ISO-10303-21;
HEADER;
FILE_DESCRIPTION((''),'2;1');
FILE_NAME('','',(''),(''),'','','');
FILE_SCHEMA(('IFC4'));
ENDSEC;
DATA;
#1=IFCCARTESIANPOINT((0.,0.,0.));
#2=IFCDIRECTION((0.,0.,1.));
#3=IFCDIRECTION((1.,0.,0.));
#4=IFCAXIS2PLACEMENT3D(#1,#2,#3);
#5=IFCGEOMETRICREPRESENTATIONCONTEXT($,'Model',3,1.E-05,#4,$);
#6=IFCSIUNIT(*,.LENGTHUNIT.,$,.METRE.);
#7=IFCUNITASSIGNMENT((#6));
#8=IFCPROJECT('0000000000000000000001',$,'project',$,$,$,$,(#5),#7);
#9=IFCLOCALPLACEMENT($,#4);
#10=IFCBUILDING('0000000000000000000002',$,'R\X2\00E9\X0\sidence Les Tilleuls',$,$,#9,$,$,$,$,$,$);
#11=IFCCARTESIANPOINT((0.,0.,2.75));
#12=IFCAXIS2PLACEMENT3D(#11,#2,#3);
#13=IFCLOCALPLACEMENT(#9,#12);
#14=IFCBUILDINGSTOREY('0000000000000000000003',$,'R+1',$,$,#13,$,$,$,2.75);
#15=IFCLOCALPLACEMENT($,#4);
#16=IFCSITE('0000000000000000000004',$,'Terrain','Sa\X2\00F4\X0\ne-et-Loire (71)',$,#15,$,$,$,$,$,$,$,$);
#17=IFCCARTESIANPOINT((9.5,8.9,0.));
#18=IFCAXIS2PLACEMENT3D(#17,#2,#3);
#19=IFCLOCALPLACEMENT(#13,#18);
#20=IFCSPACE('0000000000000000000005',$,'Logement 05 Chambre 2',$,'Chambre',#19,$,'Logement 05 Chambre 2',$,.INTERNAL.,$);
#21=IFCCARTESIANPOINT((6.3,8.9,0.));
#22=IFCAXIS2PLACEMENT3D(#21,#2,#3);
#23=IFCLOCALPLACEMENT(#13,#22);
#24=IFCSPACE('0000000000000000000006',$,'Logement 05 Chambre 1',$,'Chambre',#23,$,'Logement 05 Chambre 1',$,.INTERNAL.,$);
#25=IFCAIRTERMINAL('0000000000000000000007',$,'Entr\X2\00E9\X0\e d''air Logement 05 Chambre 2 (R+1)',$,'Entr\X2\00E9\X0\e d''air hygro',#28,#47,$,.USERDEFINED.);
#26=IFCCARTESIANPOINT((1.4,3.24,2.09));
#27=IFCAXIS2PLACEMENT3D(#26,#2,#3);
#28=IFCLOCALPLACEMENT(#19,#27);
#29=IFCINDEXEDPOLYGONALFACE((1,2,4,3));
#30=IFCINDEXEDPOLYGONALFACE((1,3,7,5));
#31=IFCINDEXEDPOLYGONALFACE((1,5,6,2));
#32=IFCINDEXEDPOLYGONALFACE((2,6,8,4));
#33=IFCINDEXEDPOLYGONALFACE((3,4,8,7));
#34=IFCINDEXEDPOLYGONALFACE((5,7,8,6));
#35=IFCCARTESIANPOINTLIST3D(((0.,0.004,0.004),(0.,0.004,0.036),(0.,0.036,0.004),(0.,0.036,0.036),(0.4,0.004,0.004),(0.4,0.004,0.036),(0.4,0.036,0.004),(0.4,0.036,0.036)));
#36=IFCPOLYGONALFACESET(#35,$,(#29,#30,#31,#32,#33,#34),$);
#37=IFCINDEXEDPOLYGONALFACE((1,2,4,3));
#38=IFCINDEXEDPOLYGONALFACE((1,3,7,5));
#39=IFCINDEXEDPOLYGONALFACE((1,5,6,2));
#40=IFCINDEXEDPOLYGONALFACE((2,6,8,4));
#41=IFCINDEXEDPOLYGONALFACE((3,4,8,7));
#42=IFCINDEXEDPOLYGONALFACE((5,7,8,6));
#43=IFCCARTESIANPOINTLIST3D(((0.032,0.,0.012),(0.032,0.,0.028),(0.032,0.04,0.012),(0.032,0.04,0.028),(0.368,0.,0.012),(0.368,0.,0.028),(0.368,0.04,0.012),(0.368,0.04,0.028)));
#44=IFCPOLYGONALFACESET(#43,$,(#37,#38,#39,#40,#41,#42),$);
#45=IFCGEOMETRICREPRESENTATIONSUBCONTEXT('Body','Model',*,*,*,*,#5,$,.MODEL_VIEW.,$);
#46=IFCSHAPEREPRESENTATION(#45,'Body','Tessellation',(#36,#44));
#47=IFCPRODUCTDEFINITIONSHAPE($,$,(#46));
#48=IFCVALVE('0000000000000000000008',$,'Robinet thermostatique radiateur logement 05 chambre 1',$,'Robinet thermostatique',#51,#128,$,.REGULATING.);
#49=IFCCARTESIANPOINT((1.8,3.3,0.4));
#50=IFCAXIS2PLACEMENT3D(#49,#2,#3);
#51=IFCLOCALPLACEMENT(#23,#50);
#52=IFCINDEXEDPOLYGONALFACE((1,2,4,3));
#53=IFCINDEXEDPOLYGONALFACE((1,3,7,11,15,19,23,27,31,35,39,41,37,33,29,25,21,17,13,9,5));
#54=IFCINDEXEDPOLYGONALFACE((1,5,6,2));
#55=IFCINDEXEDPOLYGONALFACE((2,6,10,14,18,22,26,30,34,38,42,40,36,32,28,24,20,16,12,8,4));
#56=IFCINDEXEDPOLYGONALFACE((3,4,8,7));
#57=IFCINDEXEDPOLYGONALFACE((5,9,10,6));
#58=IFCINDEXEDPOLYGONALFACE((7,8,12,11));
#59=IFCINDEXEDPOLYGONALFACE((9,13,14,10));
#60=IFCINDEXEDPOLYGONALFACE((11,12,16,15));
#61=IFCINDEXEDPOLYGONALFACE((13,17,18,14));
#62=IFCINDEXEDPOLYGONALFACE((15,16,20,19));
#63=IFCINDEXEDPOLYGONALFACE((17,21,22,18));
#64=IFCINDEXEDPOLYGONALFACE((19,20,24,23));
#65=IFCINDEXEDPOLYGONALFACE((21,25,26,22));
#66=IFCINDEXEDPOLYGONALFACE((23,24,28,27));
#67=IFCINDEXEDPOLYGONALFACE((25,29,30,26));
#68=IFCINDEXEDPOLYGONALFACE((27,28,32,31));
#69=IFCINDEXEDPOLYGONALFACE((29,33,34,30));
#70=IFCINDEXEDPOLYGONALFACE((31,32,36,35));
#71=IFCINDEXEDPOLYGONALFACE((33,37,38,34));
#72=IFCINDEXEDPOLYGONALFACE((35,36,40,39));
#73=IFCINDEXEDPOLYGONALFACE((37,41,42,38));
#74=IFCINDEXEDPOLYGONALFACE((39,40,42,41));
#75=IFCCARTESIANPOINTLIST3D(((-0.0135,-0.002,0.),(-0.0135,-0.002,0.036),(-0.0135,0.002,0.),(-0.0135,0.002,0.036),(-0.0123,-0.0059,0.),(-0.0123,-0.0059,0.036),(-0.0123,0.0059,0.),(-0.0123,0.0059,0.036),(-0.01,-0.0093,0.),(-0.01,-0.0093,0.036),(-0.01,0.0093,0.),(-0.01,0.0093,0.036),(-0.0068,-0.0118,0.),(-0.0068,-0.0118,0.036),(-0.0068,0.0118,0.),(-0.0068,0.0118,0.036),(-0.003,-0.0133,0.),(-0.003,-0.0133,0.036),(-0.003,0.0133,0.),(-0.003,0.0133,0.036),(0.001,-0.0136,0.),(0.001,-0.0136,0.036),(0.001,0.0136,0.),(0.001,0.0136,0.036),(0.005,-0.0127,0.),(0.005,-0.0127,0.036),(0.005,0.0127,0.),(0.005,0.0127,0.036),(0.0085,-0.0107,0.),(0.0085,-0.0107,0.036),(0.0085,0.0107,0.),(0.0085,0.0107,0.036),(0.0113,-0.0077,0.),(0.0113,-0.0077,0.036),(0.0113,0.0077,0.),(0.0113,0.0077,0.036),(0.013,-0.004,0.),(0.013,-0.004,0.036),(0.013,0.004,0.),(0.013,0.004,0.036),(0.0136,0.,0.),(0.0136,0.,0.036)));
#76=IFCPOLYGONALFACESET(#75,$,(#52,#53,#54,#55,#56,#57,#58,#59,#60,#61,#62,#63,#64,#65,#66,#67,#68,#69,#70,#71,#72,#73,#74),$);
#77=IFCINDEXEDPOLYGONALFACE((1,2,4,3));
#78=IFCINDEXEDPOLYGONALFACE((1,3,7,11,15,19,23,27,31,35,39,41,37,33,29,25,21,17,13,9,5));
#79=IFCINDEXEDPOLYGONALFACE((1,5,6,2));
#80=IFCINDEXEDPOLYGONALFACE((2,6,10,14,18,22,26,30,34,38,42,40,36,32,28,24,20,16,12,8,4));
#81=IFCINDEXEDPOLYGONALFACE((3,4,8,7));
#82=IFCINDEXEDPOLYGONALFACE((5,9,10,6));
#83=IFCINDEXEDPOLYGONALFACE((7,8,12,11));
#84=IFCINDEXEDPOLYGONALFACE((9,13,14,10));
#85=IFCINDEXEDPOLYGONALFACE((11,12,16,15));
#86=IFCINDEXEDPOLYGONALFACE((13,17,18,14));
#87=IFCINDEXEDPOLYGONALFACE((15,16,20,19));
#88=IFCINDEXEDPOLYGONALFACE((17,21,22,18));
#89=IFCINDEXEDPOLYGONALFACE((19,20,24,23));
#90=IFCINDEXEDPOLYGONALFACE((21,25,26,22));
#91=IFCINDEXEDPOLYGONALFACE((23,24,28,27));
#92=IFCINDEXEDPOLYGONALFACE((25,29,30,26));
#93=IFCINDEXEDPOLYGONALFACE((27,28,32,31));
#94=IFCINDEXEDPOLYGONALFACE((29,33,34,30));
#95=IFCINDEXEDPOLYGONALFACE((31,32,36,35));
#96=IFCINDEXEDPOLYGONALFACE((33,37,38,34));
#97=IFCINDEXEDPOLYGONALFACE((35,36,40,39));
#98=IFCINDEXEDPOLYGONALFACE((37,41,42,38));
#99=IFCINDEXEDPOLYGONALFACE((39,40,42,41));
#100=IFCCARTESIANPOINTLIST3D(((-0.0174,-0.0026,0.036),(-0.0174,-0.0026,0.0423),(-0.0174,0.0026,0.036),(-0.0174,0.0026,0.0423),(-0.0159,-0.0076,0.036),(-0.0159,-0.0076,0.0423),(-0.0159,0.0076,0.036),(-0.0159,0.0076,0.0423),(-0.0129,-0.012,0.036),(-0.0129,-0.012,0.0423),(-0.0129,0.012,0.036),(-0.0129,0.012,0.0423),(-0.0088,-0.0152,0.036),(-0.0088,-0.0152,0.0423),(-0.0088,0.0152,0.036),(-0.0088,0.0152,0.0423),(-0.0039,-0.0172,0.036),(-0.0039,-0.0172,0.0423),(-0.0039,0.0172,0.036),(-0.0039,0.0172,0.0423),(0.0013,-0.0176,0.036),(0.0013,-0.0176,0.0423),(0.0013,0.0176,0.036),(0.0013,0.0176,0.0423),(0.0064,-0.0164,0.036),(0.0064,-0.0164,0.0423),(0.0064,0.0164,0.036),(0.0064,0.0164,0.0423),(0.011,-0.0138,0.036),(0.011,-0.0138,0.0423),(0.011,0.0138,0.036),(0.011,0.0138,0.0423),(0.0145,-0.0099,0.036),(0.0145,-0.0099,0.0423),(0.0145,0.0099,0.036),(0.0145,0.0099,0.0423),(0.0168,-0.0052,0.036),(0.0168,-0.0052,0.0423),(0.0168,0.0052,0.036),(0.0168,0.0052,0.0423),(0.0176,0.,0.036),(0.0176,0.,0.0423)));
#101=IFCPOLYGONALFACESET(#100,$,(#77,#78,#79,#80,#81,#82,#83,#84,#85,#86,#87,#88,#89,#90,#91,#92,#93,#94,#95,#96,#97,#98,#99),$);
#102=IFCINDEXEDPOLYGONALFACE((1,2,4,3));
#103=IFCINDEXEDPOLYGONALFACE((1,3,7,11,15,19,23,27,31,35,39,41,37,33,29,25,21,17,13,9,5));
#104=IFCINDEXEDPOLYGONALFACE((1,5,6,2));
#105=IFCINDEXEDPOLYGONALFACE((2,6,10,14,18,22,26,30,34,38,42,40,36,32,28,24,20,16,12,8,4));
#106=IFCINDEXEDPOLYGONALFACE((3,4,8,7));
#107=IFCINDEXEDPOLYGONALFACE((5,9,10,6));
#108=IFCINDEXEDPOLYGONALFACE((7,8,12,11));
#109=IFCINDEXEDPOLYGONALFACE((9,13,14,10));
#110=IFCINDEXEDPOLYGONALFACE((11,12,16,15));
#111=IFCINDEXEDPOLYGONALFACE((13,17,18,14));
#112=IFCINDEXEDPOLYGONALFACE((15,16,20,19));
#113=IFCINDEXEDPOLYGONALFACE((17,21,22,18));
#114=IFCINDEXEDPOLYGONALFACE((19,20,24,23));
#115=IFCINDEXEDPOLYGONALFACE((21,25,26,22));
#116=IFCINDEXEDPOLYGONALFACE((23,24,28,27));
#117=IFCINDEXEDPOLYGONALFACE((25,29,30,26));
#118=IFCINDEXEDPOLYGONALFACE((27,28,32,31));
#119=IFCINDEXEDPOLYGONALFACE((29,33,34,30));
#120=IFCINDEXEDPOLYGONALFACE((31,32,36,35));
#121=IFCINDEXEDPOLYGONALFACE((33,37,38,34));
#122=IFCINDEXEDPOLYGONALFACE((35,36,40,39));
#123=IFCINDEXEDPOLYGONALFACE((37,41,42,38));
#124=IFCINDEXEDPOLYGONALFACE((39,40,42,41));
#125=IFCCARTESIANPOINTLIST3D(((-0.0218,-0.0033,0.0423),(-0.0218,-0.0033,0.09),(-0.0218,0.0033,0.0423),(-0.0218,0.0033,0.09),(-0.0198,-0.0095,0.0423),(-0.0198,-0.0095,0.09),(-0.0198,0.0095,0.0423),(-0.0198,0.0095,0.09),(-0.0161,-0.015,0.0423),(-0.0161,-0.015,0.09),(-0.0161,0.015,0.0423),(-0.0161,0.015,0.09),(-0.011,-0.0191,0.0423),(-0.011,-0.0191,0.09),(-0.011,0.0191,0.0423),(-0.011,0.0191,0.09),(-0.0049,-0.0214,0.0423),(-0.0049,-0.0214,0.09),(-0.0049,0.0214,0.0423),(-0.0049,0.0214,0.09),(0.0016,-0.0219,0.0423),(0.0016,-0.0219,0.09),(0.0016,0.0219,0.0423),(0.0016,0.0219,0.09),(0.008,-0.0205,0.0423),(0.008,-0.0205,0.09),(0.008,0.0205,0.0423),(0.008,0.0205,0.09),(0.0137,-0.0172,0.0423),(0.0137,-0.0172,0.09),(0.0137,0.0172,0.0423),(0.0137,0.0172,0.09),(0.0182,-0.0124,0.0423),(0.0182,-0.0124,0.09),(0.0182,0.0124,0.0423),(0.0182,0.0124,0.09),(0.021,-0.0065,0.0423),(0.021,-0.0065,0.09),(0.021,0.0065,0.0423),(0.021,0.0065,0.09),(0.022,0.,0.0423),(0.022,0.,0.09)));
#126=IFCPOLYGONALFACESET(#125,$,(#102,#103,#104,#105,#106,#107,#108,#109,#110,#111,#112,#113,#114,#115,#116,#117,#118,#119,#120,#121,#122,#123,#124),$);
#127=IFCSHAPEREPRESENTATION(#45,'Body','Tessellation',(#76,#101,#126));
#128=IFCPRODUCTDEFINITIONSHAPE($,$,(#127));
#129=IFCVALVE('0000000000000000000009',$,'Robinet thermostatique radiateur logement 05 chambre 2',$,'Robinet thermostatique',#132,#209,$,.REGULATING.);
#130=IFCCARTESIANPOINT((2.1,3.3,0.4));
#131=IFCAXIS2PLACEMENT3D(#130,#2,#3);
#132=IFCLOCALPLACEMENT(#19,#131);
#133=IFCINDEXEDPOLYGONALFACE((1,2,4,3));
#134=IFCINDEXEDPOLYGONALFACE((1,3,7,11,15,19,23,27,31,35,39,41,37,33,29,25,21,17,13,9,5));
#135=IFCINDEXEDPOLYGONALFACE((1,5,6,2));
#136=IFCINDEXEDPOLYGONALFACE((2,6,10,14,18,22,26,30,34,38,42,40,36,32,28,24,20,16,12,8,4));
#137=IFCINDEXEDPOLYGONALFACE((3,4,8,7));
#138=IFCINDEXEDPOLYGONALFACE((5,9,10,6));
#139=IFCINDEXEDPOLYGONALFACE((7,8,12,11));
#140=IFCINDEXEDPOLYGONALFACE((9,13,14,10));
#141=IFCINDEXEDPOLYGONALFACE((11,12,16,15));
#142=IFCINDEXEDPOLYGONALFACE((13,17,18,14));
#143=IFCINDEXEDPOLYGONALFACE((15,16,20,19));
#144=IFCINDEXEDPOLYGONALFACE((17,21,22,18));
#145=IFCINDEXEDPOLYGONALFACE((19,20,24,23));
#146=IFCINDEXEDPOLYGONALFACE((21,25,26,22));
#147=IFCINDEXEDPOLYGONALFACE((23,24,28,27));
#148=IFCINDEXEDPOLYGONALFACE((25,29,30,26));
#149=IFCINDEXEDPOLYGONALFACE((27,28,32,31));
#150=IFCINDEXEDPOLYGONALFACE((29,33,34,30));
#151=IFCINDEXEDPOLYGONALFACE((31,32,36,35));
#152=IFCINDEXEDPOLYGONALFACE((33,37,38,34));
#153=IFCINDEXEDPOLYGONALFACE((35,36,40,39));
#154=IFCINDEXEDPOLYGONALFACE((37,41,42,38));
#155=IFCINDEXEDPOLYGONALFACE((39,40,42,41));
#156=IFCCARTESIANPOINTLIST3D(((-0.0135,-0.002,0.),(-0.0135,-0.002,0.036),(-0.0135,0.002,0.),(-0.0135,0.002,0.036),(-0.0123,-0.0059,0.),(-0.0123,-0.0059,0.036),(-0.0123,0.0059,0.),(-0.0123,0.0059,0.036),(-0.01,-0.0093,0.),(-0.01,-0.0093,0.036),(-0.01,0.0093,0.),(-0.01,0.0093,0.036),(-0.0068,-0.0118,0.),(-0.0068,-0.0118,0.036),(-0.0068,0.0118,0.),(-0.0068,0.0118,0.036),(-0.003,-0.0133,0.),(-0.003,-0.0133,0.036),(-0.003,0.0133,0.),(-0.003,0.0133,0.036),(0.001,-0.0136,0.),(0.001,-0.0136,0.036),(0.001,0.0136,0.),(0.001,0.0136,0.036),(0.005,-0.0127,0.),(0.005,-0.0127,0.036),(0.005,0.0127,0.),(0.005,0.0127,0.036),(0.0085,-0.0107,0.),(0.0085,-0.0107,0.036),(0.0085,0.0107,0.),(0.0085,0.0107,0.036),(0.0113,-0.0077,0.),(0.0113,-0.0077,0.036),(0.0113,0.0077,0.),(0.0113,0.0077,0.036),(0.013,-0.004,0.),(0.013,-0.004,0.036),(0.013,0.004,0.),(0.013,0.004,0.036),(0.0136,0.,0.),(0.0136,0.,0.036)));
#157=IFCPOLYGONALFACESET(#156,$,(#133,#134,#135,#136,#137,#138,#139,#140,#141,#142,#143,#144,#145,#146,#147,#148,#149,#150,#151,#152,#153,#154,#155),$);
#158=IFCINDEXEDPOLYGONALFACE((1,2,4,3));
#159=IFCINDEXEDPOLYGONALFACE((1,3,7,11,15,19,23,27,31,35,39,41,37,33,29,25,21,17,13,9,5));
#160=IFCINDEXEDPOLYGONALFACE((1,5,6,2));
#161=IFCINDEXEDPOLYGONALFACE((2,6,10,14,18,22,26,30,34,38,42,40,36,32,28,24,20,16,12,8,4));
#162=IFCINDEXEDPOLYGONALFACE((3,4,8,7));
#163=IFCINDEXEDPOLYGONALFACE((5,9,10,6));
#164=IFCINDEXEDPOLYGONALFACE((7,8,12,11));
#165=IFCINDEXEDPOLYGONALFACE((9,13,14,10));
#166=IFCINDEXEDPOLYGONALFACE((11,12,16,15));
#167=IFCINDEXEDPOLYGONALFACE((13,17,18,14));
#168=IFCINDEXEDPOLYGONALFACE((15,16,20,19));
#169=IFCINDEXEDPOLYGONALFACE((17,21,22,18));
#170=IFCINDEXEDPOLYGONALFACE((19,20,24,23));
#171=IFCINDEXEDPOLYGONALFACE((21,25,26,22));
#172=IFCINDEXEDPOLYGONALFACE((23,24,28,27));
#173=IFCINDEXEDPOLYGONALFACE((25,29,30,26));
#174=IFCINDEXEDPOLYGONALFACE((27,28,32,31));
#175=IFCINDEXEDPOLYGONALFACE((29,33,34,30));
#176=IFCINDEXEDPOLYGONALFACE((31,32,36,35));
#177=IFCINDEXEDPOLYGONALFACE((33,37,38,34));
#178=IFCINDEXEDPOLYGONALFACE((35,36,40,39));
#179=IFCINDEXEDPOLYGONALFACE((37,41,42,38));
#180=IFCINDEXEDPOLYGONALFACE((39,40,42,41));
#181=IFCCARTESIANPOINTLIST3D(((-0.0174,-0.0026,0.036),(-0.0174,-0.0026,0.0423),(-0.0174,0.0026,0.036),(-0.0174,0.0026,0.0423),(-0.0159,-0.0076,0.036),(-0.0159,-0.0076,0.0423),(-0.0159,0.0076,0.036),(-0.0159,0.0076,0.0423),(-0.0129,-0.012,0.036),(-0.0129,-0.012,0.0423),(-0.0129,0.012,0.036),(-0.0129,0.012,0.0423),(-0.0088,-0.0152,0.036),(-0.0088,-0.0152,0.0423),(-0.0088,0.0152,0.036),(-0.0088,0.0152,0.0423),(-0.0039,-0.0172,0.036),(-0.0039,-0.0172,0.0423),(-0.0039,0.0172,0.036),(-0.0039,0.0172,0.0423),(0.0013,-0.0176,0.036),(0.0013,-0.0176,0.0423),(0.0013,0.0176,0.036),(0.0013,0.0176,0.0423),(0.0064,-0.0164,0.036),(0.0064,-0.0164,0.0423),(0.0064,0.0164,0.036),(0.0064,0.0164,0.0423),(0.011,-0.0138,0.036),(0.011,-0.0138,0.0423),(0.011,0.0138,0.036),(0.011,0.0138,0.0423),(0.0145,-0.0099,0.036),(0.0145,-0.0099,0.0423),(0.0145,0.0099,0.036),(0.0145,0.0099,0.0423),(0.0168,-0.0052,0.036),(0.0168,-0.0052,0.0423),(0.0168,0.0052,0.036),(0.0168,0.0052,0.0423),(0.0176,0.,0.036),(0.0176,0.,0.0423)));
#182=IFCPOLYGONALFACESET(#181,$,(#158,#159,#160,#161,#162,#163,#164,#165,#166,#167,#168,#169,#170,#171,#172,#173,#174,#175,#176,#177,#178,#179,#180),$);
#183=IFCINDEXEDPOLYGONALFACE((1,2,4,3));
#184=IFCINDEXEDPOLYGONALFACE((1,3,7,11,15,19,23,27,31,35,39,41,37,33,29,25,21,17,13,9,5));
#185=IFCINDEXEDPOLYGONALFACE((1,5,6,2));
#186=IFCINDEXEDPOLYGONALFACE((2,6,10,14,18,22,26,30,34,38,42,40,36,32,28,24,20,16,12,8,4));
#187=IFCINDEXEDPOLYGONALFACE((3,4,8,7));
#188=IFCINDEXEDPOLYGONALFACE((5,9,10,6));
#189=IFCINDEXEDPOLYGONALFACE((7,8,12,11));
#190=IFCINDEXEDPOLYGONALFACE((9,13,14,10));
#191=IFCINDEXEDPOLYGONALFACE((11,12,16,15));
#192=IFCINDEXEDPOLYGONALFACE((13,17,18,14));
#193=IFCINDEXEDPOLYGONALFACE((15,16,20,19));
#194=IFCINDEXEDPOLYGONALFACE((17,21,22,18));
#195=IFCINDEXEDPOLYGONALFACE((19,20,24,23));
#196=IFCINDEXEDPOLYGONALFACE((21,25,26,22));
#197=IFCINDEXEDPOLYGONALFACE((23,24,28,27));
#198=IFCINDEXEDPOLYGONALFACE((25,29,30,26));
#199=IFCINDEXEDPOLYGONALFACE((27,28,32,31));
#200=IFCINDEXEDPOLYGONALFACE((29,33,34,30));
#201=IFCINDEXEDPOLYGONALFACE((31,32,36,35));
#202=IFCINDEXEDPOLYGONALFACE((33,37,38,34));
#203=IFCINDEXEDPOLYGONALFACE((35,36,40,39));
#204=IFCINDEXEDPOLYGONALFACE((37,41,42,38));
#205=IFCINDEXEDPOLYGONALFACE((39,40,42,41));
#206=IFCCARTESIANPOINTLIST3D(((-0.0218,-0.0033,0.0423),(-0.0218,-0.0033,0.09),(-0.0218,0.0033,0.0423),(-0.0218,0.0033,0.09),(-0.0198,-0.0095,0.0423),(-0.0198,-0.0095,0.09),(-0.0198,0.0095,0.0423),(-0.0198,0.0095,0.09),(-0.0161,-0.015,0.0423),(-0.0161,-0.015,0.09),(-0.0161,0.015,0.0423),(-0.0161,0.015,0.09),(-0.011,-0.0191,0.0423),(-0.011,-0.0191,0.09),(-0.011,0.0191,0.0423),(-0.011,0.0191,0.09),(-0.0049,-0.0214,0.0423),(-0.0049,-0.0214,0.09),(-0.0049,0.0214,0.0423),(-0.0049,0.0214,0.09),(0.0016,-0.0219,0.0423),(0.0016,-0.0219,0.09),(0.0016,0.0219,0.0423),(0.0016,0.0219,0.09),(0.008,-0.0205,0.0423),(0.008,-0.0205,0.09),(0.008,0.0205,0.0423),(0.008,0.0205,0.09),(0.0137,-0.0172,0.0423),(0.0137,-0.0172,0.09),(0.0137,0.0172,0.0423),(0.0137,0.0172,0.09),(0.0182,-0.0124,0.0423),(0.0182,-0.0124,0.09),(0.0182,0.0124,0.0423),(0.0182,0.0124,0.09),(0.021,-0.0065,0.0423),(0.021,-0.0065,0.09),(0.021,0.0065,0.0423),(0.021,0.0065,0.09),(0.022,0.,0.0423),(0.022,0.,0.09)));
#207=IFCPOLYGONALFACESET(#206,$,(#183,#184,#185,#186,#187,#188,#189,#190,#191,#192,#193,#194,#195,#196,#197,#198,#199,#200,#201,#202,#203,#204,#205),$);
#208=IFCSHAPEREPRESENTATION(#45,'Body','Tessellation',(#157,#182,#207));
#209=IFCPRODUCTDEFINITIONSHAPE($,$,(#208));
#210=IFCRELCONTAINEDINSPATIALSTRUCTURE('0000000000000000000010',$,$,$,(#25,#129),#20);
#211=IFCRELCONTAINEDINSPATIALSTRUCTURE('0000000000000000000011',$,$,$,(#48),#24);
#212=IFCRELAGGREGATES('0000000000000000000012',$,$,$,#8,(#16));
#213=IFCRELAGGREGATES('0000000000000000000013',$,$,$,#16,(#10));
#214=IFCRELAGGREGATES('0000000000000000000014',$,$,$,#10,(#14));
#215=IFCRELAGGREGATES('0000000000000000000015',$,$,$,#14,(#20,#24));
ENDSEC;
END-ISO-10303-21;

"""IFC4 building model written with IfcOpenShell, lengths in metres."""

from ifc_helpers import new_model, si_unit, frame, frame_2d, origin_with_axes, place, context, subcontext, project, spatial, rectangle, circle, extrude, element, save


model = new_model("IFC4")

# Units and contexts
model_context = context("Model", 3, precision=1e-05, world=origin_with_axes())
body_context = subcontext(model_context, "Body", "Model", "MODEL_VIEW")
ifc_project = project(units=[si_unit("LENGTHUNIT", "METRE")], contexts=[model_context])

# Site, building, storey
site_placement = place(None, origin_with_axes())
site = spatial("IfcSite", under=ifc_project, at=site_placement, Name="Terrain", Description="Saône-et-Loire (71)")
building_placement = place(None, origin_with_axes())
building = spatial("IfcBuilding", under=site, at=building_placement, Name="Résidence Les Tilleuls")
storey_placement = place(building_placement, frame((0.0, 0.0, 2.75), z_axis=(0.0, 0.0, 1.0), x_axis=(1.0, 0.0, 0.0)))
storey = spatial("IfcBuildingStorey", under=building, at=storey_placement, Name="R+1", Elevation=2.75)

# Shared definitions
space_1_placement = place(storey_placement, frame((9.5, 8.9, 0.0), z_axis=(0.0, 0.0, 1.0), x_axis=(1.0, 0.0, 0.0)))
space_1 = spatial("IfcSpace", under=storey, at=space_1_placement, Name="Logement 05 Chambre 2", ObjectType="Chambre", LongName="Logement 05 Chambre 2", PredefinedType="INTERNAL")

# Air terminal
air_terminal_1_placement = place(space_1_placement, frame((1.4, 3.24, 2.09), z_axis=(0.0, 0.0, 1.0), x_axis=(1.0, 0.0, 0.0)))
element("IfcAirTerminal", 1, at=air_terminal_1_placement, inside=space_1, Name="Entrée d'air Logement 05 Chambre 2 (R+1)", ObjectType="Entrée d'air hygro", PredefinedType="USERDEFINED", context=body_context, shape_type="SweptSolid", body=[
    extrude(rectangle(XDim=0.4, YDim=0.032, at=frame_2d((0.2, 0.016))), frame((0.0, 0.004, 0.004), z_axis=(0.0, 0.0, 1.0), x_axis=(1.0, 0.0, 0.0)), (0.0, 0.0, 1.0), 0.032),
    extrude(rectangle(XDim=0.336, YDim=0.04, at=frame_2d((0.168, 0.02))), frame((0.032, 0.0, 0.012), z_axis=(0.0, 0.0, 1.0), x_axis=(1.0, 0.0, 0.0)), (0.0, 0.0, 1.0), 0.016),
])

# Shared definitions
space_2_placement = place(storey_placement, frame((6.3, 8.9, 0.0), z_axis=(0.0, 0.0, 1.0), x_axis=(1.0, 0.0, 0.0)))
space_2 = spatial("IfcSpace", under=storey, at=space_2_placement, Name="Logement 05 Chambre 1", ObjectType="Chambre", LongName="Logement 05 Chambre 1", PredefinedType="INTERNAL")

# Valve
valve_1_placement = place(space_2_placement, frame((1.8, 3.3, 0.4), z_axis=(0.0, 0.0, 1.0), x_axis=(1.0, 0.0, 0.0)))
element("IfcValve", 2, at=valve_1_placement, inside=space_2, Name="Robinet thermostatique radiateur logement 05 chambre 1", ObjectType="Robinet thermostatique", PredefinedType="REGULATING", context=body_context, shape_type="SweptSolid", body=[
    extrude(circle(Radius=0.0136), origin_with_axes(), (0.0, 0.0, 1.0), 0.036),
    extrude(circle(Radius=0.0176), frame((0.0, 0.0, 0.036), z_axis=(0.0, 0.0, 1.0), x_axis=(1.0, 0.0, 0.0)), (0.0, 0.0, 1.0), 0.0063),
    extrude(circle(Radius=0.022), frame((0.0, 0.0, 0.0423), z_axis=(0.0, 0.0, 1.0), x_axis=(1.0, 0.0, 0.0)), (0.0, 0.0, 1.0), 0.0477),
])

# Valve
valve_2_placement = place(space_1_placement, frame((2.1, 3.3, 0.4), z_axis=(0.0, 0.0, 1.0), x_axis=(1.0, 0.0, 0.0)))
element("IfcValve", 3, at=valve_2_placement, inside=space_1, Name="Robinet thermostatique radiateur logement 05 chambre 2", ObjectType="Robinet thermostatique", PredefinedType="REGULATING", context=body_context, shape_type="SweptSolid", body=[
    extrude(circle(Radius=0.0136), origin_with_axes(), (0.0, 0.0, 1.0), 0.036),
    extrude(circle(Radius=0.0176), frame((0.0, 0.0, 0.036), z_axis=(0.0, 0.0, 1.0), x_axis=(1.0, 0.0, 0.0)), (0.0, 0.0, 1.0), 0.0063),
    extrude(circle(Radius=0.022), frame((0.0, 0.0, 0.0423), z_axis=(0.0, 0.0, 1.0), x_axis=(1.0, 0.0, 0.0)), (0.0, 0.0, 1.0), 0.0477),
])

save(model, "model.ifc")
